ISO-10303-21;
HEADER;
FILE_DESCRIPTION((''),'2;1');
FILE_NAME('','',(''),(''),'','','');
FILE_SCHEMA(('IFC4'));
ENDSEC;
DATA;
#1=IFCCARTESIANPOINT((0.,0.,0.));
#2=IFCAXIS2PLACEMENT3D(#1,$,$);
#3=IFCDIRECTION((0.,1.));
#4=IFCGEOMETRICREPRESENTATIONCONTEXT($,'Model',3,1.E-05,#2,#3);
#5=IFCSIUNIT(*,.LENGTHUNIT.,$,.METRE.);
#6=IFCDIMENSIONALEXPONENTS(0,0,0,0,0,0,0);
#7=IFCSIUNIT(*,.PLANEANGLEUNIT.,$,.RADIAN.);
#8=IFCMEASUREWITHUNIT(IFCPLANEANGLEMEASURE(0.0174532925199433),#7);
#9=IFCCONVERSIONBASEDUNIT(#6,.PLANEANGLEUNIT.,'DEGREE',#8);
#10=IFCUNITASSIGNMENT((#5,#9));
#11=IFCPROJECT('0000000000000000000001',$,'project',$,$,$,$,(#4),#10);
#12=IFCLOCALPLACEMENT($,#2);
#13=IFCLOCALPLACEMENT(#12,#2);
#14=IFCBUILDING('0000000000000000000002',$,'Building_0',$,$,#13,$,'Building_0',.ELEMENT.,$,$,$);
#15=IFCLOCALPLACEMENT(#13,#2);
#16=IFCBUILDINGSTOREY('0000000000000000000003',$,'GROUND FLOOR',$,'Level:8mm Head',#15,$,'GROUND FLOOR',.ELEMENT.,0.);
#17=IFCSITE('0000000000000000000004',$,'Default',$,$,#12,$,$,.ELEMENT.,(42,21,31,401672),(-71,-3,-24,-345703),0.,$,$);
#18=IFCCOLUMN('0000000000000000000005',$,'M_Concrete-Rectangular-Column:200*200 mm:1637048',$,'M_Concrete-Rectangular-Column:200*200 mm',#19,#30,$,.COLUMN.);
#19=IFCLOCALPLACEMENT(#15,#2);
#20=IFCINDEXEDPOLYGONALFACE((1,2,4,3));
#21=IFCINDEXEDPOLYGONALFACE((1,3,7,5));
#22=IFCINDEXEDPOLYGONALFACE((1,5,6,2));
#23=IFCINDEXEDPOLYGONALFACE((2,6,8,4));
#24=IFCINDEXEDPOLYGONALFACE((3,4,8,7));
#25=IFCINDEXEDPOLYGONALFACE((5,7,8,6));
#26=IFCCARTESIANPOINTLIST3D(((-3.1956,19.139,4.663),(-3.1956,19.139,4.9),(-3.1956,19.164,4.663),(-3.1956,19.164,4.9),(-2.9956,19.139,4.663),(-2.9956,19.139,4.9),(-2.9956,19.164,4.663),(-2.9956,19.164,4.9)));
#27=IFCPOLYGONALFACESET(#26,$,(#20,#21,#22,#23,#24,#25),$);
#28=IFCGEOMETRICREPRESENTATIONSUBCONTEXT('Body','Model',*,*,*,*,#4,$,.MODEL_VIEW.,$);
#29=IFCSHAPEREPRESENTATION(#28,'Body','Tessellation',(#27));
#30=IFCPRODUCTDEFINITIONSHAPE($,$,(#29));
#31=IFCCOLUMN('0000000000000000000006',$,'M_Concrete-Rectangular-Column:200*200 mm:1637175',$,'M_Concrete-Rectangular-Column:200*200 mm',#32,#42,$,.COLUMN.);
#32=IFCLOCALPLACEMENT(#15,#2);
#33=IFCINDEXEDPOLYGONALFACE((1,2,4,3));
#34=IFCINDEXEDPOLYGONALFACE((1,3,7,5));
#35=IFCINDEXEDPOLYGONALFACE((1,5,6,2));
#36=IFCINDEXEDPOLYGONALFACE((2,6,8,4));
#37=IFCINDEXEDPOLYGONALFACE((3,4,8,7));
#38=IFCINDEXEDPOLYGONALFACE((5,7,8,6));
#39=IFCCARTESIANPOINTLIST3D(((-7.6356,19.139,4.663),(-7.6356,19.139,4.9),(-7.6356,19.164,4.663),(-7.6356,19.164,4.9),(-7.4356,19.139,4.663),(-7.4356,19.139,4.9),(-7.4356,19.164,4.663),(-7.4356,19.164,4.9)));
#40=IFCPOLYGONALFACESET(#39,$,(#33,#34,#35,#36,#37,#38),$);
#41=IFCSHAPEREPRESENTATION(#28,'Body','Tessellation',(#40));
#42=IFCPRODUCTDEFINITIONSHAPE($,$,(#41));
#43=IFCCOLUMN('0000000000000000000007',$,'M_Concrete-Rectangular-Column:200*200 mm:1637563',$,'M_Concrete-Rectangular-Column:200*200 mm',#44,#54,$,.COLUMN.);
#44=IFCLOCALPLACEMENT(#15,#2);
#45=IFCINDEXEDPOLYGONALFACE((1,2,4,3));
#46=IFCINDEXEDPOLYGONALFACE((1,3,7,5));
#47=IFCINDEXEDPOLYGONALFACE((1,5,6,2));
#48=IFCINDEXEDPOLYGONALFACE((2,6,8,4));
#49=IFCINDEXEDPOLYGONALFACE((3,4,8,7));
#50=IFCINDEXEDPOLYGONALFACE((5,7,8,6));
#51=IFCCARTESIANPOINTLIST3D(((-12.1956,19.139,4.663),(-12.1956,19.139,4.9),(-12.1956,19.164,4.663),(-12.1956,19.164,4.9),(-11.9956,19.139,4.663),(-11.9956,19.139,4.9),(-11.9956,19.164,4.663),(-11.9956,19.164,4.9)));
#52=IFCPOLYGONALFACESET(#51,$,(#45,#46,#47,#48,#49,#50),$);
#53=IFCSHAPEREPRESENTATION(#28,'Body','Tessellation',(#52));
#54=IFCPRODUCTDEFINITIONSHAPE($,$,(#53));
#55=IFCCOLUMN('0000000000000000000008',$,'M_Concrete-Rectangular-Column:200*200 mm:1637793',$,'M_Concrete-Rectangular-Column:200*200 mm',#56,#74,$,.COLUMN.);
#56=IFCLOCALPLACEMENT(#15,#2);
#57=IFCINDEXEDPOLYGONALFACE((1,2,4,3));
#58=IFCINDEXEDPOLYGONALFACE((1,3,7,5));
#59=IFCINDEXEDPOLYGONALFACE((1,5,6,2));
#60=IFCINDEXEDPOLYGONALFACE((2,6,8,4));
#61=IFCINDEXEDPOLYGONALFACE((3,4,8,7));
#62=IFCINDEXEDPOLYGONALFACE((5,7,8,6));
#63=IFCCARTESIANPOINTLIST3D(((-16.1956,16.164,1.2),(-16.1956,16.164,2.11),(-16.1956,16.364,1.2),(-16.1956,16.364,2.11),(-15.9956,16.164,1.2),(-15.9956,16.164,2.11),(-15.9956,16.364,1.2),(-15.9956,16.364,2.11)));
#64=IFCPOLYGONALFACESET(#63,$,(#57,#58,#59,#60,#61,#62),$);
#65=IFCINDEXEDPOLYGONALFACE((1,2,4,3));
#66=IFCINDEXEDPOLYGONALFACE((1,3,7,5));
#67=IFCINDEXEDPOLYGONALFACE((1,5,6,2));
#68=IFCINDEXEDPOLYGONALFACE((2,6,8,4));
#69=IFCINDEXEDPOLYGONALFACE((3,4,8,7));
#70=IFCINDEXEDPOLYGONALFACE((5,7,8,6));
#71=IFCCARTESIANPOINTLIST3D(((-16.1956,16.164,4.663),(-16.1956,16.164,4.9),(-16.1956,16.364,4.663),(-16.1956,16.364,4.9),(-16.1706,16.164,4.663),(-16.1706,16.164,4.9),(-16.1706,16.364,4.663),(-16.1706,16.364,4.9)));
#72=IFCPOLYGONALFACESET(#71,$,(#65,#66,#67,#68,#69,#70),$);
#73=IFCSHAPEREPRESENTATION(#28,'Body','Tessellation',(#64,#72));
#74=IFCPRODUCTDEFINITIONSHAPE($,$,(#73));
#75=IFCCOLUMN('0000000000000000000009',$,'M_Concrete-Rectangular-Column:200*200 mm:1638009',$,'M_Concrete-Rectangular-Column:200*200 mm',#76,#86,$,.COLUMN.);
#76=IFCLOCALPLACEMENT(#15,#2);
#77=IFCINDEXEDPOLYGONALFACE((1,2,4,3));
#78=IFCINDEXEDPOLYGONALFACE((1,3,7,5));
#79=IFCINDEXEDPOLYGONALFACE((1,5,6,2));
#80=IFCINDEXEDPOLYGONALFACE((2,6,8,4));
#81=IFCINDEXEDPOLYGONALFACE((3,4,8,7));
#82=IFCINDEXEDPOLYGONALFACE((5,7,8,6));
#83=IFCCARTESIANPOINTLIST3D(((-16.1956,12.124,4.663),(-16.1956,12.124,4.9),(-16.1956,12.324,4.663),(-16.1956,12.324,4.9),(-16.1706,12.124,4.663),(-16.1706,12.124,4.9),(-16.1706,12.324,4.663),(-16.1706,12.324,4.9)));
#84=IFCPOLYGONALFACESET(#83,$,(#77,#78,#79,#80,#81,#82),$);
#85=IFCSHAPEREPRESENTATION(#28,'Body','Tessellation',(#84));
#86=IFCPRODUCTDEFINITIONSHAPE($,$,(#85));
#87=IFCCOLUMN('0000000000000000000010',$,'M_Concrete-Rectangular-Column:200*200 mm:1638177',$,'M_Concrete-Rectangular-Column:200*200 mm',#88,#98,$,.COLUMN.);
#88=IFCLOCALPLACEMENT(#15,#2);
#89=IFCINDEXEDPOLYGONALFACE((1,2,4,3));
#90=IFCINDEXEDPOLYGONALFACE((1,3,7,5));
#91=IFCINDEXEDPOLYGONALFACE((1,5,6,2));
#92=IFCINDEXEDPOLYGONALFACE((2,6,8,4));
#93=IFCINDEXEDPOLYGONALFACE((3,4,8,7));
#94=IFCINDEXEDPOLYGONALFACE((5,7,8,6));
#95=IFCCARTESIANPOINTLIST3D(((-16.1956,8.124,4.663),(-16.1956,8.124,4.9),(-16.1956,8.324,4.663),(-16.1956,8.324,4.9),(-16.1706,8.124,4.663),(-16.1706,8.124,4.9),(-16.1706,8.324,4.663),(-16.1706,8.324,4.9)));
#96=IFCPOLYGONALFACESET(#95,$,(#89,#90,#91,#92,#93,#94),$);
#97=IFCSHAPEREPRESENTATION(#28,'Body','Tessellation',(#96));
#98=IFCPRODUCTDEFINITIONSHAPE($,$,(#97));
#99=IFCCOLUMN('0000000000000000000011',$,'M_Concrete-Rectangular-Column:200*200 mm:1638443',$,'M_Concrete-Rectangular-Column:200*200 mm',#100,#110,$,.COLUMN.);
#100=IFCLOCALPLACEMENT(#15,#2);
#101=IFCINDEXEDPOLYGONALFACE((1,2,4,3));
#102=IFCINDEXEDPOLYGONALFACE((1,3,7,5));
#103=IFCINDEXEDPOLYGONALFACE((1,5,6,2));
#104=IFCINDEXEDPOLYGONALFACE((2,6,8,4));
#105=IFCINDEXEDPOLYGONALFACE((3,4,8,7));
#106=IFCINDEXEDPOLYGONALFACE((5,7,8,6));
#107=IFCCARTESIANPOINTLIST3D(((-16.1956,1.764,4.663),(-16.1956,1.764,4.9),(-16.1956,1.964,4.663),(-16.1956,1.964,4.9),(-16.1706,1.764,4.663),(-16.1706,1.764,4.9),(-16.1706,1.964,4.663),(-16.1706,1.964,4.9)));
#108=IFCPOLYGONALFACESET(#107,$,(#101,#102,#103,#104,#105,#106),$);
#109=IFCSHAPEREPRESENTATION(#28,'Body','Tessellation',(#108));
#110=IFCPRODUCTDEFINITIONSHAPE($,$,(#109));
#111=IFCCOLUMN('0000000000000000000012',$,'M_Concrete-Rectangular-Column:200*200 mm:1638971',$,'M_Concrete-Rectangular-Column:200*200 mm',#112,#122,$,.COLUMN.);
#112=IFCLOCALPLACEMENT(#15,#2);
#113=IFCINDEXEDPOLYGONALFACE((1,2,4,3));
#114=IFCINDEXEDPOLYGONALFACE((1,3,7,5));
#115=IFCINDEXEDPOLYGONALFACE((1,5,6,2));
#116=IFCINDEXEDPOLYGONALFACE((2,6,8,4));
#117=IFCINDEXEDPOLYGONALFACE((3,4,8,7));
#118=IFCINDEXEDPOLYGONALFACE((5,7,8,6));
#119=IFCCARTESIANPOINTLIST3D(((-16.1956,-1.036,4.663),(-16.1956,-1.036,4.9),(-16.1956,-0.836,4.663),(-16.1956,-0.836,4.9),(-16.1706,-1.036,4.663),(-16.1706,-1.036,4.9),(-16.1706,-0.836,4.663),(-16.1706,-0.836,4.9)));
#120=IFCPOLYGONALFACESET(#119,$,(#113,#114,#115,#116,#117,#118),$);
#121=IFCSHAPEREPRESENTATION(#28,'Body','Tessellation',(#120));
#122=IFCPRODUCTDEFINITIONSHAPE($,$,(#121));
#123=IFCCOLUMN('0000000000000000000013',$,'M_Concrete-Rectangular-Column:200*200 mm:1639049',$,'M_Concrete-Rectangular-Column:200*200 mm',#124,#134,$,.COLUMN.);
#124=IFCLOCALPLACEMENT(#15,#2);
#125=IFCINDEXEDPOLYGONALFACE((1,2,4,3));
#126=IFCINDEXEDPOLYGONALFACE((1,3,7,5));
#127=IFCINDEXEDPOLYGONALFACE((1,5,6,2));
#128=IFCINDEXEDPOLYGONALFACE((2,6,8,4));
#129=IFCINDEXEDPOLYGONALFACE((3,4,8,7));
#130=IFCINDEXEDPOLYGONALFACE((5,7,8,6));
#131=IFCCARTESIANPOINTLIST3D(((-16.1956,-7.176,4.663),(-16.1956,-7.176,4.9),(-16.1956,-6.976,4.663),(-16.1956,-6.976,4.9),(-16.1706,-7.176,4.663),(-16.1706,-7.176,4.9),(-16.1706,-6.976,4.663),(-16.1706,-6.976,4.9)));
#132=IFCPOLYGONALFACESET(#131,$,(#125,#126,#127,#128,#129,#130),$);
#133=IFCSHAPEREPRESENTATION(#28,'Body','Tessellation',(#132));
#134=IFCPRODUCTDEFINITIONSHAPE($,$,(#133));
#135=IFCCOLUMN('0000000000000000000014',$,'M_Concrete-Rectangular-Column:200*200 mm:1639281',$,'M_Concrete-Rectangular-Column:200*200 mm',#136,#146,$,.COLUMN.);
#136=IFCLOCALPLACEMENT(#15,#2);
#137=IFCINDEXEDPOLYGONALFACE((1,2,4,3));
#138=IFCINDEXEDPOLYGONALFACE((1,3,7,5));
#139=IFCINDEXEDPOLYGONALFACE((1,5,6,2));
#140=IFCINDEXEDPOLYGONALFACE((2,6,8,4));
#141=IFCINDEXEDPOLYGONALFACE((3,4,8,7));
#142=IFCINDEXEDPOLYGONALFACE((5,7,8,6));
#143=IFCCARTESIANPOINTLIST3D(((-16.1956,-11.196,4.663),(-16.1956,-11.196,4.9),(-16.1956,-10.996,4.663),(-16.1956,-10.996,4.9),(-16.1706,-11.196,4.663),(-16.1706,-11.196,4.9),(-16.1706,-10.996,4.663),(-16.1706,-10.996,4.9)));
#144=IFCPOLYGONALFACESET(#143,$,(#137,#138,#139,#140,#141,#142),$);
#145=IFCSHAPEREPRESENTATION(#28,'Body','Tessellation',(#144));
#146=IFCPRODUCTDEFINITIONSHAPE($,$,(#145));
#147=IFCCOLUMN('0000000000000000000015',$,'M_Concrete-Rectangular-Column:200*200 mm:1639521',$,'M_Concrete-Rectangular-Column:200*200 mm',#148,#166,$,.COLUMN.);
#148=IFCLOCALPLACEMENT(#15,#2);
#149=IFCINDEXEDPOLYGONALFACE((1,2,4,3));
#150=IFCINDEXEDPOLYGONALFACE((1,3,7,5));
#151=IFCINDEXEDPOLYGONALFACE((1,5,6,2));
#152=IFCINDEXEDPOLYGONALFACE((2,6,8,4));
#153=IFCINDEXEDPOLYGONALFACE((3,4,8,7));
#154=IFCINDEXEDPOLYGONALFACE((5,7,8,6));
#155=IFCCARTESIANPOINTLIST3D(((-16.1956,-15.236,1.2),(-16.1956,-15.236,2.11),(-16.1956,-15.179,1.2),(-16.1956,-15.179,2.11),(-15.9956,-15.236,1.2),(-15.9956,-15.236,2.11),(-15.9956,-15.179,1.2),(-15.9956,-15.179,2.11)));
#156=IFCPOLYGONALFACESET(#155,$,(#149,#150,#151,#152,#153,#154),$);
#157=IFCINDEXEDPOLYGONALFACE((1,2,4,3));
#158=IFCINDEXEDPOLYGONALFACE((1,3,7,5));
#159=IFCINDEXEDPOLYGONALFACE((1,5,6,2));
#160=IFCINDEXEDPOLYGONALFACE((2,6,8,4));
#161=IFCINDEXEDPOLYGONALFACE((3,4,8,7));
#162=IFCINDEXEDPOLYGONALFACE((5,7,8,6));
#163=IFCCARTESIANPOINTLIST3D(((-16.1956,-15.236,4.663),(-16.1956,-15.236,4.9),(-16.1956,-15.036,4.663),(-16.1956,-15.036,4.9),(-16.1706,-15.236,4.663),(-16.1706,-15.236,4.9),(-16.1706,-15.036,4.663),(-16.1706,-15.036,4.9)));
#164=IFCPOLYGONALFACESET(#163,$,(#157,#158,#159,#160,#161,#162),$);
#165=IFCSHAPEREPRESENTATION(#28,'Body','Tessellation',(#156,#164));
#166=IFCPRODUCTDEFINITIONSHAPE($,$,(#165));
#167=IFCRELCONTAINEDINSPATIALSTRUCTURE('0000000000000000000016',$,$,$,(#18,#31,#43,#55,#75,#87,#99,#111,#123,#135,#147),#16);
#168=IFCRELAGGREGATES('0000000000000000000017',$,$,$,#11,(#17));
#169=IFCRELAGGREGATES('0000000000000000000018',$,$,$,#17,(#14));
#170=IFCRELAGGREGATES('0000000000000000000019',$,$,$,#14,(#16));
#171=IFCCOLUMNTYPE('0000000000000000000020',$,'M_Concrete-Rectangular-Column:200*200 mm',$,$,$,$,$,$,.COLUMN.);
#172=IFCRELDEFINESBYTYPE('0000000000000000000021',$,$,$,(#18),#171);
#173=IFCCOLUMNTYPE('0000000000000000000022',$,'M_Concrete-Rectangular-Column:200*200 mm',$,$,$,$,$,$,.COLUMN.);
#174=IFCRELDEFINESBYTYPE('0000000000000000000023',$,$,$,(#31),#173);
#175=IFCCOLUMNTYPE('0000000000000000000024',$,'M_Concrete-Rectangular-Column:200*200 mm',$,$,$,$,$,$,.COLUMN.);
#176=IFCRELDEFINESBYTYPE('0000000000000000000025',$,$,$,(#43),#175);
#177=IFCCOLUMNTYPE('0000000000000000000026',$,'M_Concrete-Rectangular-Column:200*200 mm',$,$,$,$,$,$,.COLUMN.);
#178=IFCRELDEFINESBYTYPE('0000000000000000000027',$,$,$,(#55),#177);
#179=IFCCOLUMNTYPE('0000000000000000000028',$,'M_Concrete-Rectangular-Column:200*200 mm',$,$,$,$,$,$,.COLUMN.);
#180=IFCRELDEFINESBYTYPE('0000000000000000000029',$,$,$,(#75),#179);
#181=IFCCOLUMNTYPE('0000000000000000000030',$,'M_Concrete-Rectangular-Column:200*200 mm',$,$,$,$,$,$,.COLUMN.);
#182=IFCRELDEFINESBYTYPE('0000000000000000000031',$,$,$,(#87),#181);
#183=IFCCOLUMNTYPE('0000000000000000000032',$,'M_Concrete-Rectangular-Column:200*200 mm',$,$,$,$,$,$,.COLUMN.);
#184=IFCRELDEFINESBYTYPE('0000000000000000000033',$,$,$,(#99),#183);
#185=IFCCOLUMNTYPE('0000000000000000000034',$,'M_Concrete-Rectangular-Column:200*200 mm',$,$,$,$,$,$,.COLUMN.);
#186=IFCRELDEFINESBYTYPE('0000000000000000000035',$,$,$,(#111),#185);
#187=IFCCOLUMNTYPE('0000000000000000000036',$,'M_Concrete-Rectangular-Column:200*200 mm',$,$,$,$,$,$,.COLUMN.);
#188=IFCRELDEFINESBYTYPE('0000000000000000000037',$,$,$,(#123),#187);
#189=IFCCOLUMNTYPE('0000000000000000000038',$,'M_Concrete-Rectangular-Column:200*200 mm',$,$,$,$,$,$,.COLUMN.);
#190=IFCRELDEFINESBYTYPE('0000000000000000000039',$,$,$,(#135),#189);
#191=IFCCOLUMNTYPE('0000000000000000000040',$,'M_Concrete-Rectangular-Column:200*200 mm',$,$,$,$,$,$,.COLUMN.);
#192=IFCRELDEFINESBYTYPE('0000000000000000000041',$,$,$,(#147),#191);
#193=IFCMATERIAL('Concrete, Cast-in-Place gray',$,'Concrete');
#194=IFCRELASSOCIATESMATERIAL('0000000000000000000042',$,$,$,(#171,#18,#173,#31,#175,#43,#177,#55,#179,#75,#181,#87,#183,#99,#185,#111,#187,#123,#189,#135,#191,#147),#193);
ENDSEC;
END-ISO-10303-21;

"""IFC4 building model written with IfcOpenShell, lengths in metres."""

from ifc_helpers import new_model, entity, si_unit, converted_unit, direction, frame, origin, place, context, subcontext, project, spatial, indexed_curve, outline, extrude, source, transform, mapped, material, type_object, type_shapes, element, save


model = new_model("IFC4")

# Units and contexts
model_context = context("Model", 3, precision=1e-05, world=origin(), true_north=direction((0.0, 1.0)))
body_context = subcontext(model_context, "Body", "Model", "MODEL_VIEW")
ifc_project = project(units=[si_unit("LENGTHUNIT", "METRE"), converted_unit("PLANEANGLEUNIT", "DEGREE", entity("IfcPlaneAngleMeasure", 0.0174532925199433), si_unit("PLANEANGLEUNIT", "RADIAN"), dimensions=[0, 0, 0, 0, 0, 0, 0])], contexts=[model_context])

# Site, building, storey
site_placement = place(None, origin())
site = spatial("IfcSite", under=ifc_project, at=site_placement, Name="Default", CompositionType="ELEMENT", RefLatitude=(42, 21, 31, 401672), RefLongitude=(-71, -3, -24, -345703), RefElevation=0.0)
building_placement = place(site_placement, origin())
building = spatial("IfcBuilding", under=site, at=building_placement, Name="Building_0", LongName="Building_0", CompositionType="ELEMENT")
storey_placement = place(building_placement, origin())
storey = spatial("IfcBuildingStorey", under=building, at=storey_placement, Name="GROUND FLOOR", ObjectType="Level:8mm Head", LongName="GROUND FLOOR", CompositionType="ELEMENT", Elevation=0.0)

# Columns
ifc_material_1 = material(Name="Concrete, Cast-in-Place gray", Category="Concrete")
column_type_1 = type_object("IfcColumnType", Name="M_Concrete-Rectangular-Column:200*200 mm", PredefinedType="COLUMN", material=ifc_material_1)
shared_shape_1 = source(origin(), body_context, "Body", "SweptSolid", [
    extrude(outline(indexed_curve([(-0.0125, -0.1185), (0.0125, -0.1185), (0.0125, 0.1185), (-0.0125, 0.1185), (-0.0125, -0.1185)], self_intersect=False)), frame((-3.1956, 19.1515, 4.7815), z_axis=(1.0, 0.0, 0.0), x_axis=(0.0, 1.0, 0.0)), (0.0, 0.0, 1.0), 0.2),
])
type_shapes(column_type_1, [shared_shape_1])
column_1_placement = place(storey_placement, origin())
element("IfcColumn", 1, at=column_1_placement, inside=storey, type_object=column_type_1, material=ifc_material_1, Name="M_Concrete-Rectangular-Column:200*200 mm:1637048", ObjectType="M_Concrete-Rectangular-Column:200*200 mm", PredefinedType="COLUMN", context=body_context, shape_type="MappedRepresentation", body=[
    mapped(shared_shape_1, transform((0.0, 0.0, 0.0), scale=1.0)),
])
column_type_2 = type_object("IfcColumnType", Name="M_Concrete-Rectangular-Column:200*200 mm", PredefinedType="COLUMN", material=ifc_material_1)
shared_shape_2 = source(origin(), body_context, "Body", "SweptSolid", [
    extrude(outline(indexed_curve([(-0.0125, -0.1185), (0.0125, -0.1185), (0.0125, 0.1185), (-0.0125, 0.1185), (-0.0125, -0.1185)], self_intersect=False)), frame((-7.6356, 19.1515, 4.7815), z_axis=(1.0, 0.0, 0.0), x_axis=(0.0, 1.0, 0.0)), (0.0, 0.0, 1.0), 0.2),
])
type_shapes(column_type_2, [shared_shape_2])
column_2_placement = place(storey_placement, origin())
element("IfcColumn", 2, at=column_2_placement, inside=storey, type_object=column_type_2, material=ifc_material_1, Name="M_Concrete-Rectangular-Column:200*200 mm:1637175", ObjectType="M_Concrete-Rectangular-Column:200*200 mm", PredefinedType="COLUMN", context=body_context, shape_type="MappedRepresentation", body=[
    mapped(shared_shape_2, transform((0.0, 0.0, 0.0), scale=1.0)),
])
column_type_3 = type_object("IfcColumnType", Name="M_Concrete-Rectangular-Column:200*200 mm", PredefinedType="COLUMN", material=ifc_material_1)
shared_shape_3 = source(origin(), body_context, "Body", "SweptSolid", [
    extrude(outline(indexed_curve([(-0.0125, -0.1185), (0.0125, -0.1185), (0.0125, 0.1185), (-0.0125, 0.1185), (-0.0125, -0.1185)], self_intersect=False)), frame((-12.1956, 19.1515, 4.7815), z_axis=(1.0, 0.0, 0.0), x_axis=(0.0, 1.0, 0.0)), (0.0, 0.0, 1.0), 0.2),
])
type_shapes(column_type_3, [shared_shape_3])
column_3_placement = place(storey_placement, origin())
element("IfcColumn", 3, at=column_3_placement, inside=storey, type_object=column_type_3, material=ifc_material_1, Name="M_Concrete-Rectangular-Column:200*200 mm:1637563", ObjectType="M_Concrete-Rectangular-Column:200*200 mm", PredefinedType="COLUMN", context=body_context, shape_type="MappedRepresentation", body=[
    mapped(shared_shape_3, transform((0.0, 0.0, 0.0), scale=1.0)),
])
column_type_4 = type_object("IfcColumnType", Name="M_Concrete-Rectangular-Column:200*200 mm", PredefinedType="COLUMN", material=ifc_material_1)
shared_shape_4 = source(origin(), body_context, "Body", "SweptSolid", [
    extrude(outline(indexed_curve([(-0.1, -0.1), (0.1, -0.1), (0.1, 0.1), (-0.1, 0.1), (-0.1, -0.1)], self_intersect=False)), frame((-16.0956, 16.264, 1.2), z_axis=(0.0, 0.0, 1.0), x_axis=(-1.0, 0.0, 0.0)), (0.0, 0.0, 1.0), 0.91),
    extrude(outline(indexed_curve([(-0.1, -0.0125), (0.1, -0.0125), (0.1, 0.0125), (-0.1, 0.0125), (-0.1, -0.0125)], self_intersect=False)), frame((-16.1831, 16.264, 4.663), z_axis=(0.0, 0.0, 1.0), x_axis=(0.0, 1.0, 0.0)), (0.0, 0.0, 1.0), 0.237),
])
type_shapes(column_type_4, [shared_shape_4])
column_4_placement = place(storey_placement, origin())
element("IfcColumn", 4, at=column_4_placement, inside=storey, type_object=column_type_4, material=ifc_material_1, Name="M_Concrete-Rectangular-Column:200*200 mm:1637793", ObjectType="M_Concrete-Rectangular-Column:200*200 mm", PredefinedType="COLUMN", context=body_context, shape_type="MappedRepresentation", body=[
    mapped(shared_shape_4, transform((0.0, 0.0, 0.0), scale=1.0)),
])
column_type_5 = type_object("IfcColumnType", Name="M_Concrete-Rectangular-Column:200*200 mm", PredefinedType="COLUMN", material=ifc_material_1)
shared_shape_5 = source(origin(), body_context, "Body", "SweptSolid", [
    extrude(outline(indexed_curve([(-0.1, -0.0125), (0.1, -0.0125), (0.1, 0.0125), (-0.1, 0.0125), (-0.1, -0.0125)], self_intersect=False)), frame((-16.1831, 12.224, 4.663), z_axis=(0.0, 0.0, 1.0), x_axis=(0.0, 1.0, 0.0)), (0.0, 0.0, 1.0), 0.237),
])
type_shapes(column_type_5, [shared_shape_5])
column_5_placement = place(storey_placement, origin())
element("IfcColumn", 5, at=column_5_placement, inside=storey, type_object=column_type_5, material=ifc_material_1, Name="M_Concrete-Rectangular-Column:200*200 mm:1638009", ObjectType="M_Concrete-Rectangular-Column:200*200 mm", PredefinedType="COLUMN", context=body_context, shape_type="MappedRepresentation", body=[
    mapped(shared_shape_5, transform((0.0, 0.0, 0.0), scale=1.0)),
])
column_type_6 = type_object("IfcColumnType", Name="M_Concrete-Rectangular-Column:200*200 mm", PredefinedType="COLUMN", material=ifc_material_1)
shared_shape_6 = source(origin(), body_context, "Body", "SweptSolid", [
    extrude(outline(indexed_curve([(-0.1, -0.0125), (0.1, -0.0125), (0.1, 0.0125), (-0.1, 0.0125), (-0.1, -0.0125)], self_intersect=False)), frame((-16.1831, 8.224, 4.663), z_axis=(0.0, 0.0, 1.0), x_axis=(0.0, 1.0, 0.0)), (0.0, 0.0, 1.0), 0.237),
])
type_shapes(column_type_6, [shared_shape_6])
column_6_placement = place(storey_placement, origin())
element("IfcColumn", 6, at=column_6_placement, inside=storey, type_object=column_type_6, material=ifc_material_1, Name="M_Concrete-Rectangular-Column:200*200 mm:1638177", ObjectType="M_Concrete-Rectangular-Column:200*200 mm", PredefinedType="COLUMN", context=body_context, shape_type="MappedRepresentation", body=[
    mapped(shared_shape_6, transform((0.0, 0.0, 0.0), scale=1.0)),
])
column_type_7 = type_object("IfcColumnType", Name="M_Concrete-Rectangular-Column:200*200 mm", PredefinedType="COLUMN", material=ifc_material_1)
shared_shape_7 = source(origin(), body_context, "Body", "SweptSolid", [
    extrude(outline(indexed_curve([(-0.1, -0.0125), (0.1, -0.0125), (0.1, 0.0125), (-0.1, 0.0125), (-0.1, -0.0125)], self_intersect=False)), frame((-16.1831, 1.864, 4.663), z_axis=(0.0, 0.0, 1.0), x_axis=(0.0, 1.0, 0.0)), (0.0, 0.0, 1.0), 0.237),
])
type_shapes(column_type_7, [shared_shape_7])
column_7_placement = place(storey_placement, origin())
element("IfcColumn", 7, at=column_7_placement, inside=storey, type_object=column_type_7, material=ifc_material_1, Name="M_Concrete-Rectangular-Column:200*200 mm:1638443", ObjectType="M_Concrete-Rectangular-Column:200*200 mm", PredefinedType="COLUMN", context=body_context, shape_type="MappedRepresentation", body=[
    mapped(shared_shape_7, transform((0.0, 0.0, 0.0), scale=1.0)),
])
column_type_8 = type_object("IfcColumnType", Name="M_Concrete-Rectangular-Column:200*200 mm", PredefinedType="COLUMN", material=ifc_material_1)
shared_shape_8 = source(origin(), body_context, "Body", "SweptSolid", [
    extrude(outline(indexed_curve([(-0.1, -0.0125), (0.1, -0.0125), (0.1, 0.0125), (-0.1, 0.0125), (-0.1, -0.0125)], self_intersect=False)), frame((-16.1831, -0.936, 4.663), z_axis=(0.0, 0.0, 1.0), x_axis=(0.0, 1.0, 0.0)), (0.0, 0.0, 1.0), 0.237),
])
type_shapes(column_type_8, [shared_shape_8])
column_8_placement = place(storey_placement, origin())
element("IfcColumn", 8, at=column_8_placement, inside=storey, type_object=column_type_8, material=ifc_material_1, Name="M_Concrete-Rectangular-Column:200*200 mm:1638971", ObjectType="M_Concrete-Rectangular-Column:200*200 mm", PredefinedType="COLUMN", context=body_context, shape_type="MappedRepresentation", body=[
    mapped(shared_shape_8, transform((0.0, 0.0, 0.0), scale=1.0)),
])
column_type_9 = type_object("IfcColumnType", Name="M_Concrete-Rectangular-Column:200*200 mm", PredefinedType="COLUMN", material=ifc_material_1)
shared_shape_9 = source(origin(), body_context, "Body", "SweptSolid", [
    extrude(outline(indexed_curve([(-0.1, -0.0125), (0.1, -0.0125), (0.1, 0.0125), (-0.1, 0.0125), (-0.1, -0.0125)], self_intersect=False)), frame((-16.1831, -7.076, 4.663), z_axis=(0.0, 0.0, 1.0), x_axis=(0.0, 1.0, 0.0)), (0.0, 0.0, 1.0), 0.237),
])
type_shapes(column_type_9, [shared_shape_9])
column_9_placement = place(storey_placement, origin())
element("IfcColumn", 9, at=column_9_placement, inside=storey, type_object=column_type_9, material=ifc_material_1, Name="M_Concrete-Rectangular-Column:200*200 mm:1639049", ObjectType="M_Concrete-Rectangular-Column:200*200 mm", PredefinedType="COLUMN", context=body_context, shape_type="MappedRepresentation", body=[
    mapped(shared_shape_9, transform((0.0, 0.0, 0.0), scale=1.0)),
])
column_type_10 = type_object("IfcColumnType", Name="M_Concrete-Rectangular-Column:200*200 mm", PredefinedType="COLUMN", material=ifc_material_1)
shared_shape_10 = source(origin(), body_context, "Body", "SweptSolid", [
    extrude(outline(indexed_curve([(-0.1, -0.0125), (0.1, -0.0125), (0.1, 0.0125), (-0.1, 0.0125), (-0.1, -0.0125)], self_intersect=False)), frame((-16.1831, -11.096, 4.663), z_axis=(0.0, 0.0, 1.0), x_axis=(0.0, 1.0, 0.0)), (0.0, 0.0, 1.0), 0.237),
])
type_shapes(column_type_10, [shared_shape_10])
column_10_placement = place(storey_placement, origin())
element("IfcColumn", 10, at=column_10_placement, inside=storey, type_object=column_type_10, material=ifc_material_1, Name="M_Concrete-Rectangular-Column:200*200 mm:1639281", ObjectType="M_Concrete-Rectangular-Column:200*200 mm", PredefinedType="COLUMN", context=body_context, shape_type="MappedRepresentation", body=[
    mapped(shared_shape_10, transform((0.0, 0.0, 0.0), scale=1.0)),
])
column_type_11 = type_object("IfcColumnType", Name="M_Concrete-Rectangular-Column:200*200 mm", PredefinedType="COLUMN", material=ifc_material_1)
shared_shape_11 = source(origin(), body_context, "Body", "SweptSolid", [
    extrude(outline(indexed_curve([(-0.0285, -0.1), (0.0285, -0.1), (0.0285, 0.1), (-0.0285, 0.1), (-0.0285, -0.1)], self_intersect=False)), frame((-16.0956, -15.2075, 1.2), z_axis=(0.0, 0.0, 1.0), x_axis=(0.0, -1.0, 0.0)), (0.0, 0.0, 1.0), 0.91),
    extrude(outline(indexed_curve([(-0.1, -0.0125), (0.1, -0.0125), (0.1, 0.0125), (-0.1, 0.0125), (-0.1, -0.0125)], self_intersect=False)), frame((-16.1831, -15.136, 4.663), z_axis=(0.0, 0.0, 1.0), x_axis=(0.0, 1.0, 0.0)), (0.0, 0.0, 1.0), 0.237),
])
type_shapes(column_type_11, [shared_shape_11])
column_11_placement = place(storey_placement, origin())
element("IfcColumn", 11, at=column_11_placement, inside=storey, type_object=column_type_11, material=ifc_material_1, Name="M_Concrete-Rectangular-Column:200*200 mm:1639521", ObjectType="M_Concrete-Rectangular-Column:200*200 mm", PredefinedType="COLUMN", context=body_context, shape_type="MappedRepresentation", body=[
    mapped(shared_shape_11, transform((0.0, 0.0, 0.0), scale=1.0)),
])

save(model, "model.ifc")
